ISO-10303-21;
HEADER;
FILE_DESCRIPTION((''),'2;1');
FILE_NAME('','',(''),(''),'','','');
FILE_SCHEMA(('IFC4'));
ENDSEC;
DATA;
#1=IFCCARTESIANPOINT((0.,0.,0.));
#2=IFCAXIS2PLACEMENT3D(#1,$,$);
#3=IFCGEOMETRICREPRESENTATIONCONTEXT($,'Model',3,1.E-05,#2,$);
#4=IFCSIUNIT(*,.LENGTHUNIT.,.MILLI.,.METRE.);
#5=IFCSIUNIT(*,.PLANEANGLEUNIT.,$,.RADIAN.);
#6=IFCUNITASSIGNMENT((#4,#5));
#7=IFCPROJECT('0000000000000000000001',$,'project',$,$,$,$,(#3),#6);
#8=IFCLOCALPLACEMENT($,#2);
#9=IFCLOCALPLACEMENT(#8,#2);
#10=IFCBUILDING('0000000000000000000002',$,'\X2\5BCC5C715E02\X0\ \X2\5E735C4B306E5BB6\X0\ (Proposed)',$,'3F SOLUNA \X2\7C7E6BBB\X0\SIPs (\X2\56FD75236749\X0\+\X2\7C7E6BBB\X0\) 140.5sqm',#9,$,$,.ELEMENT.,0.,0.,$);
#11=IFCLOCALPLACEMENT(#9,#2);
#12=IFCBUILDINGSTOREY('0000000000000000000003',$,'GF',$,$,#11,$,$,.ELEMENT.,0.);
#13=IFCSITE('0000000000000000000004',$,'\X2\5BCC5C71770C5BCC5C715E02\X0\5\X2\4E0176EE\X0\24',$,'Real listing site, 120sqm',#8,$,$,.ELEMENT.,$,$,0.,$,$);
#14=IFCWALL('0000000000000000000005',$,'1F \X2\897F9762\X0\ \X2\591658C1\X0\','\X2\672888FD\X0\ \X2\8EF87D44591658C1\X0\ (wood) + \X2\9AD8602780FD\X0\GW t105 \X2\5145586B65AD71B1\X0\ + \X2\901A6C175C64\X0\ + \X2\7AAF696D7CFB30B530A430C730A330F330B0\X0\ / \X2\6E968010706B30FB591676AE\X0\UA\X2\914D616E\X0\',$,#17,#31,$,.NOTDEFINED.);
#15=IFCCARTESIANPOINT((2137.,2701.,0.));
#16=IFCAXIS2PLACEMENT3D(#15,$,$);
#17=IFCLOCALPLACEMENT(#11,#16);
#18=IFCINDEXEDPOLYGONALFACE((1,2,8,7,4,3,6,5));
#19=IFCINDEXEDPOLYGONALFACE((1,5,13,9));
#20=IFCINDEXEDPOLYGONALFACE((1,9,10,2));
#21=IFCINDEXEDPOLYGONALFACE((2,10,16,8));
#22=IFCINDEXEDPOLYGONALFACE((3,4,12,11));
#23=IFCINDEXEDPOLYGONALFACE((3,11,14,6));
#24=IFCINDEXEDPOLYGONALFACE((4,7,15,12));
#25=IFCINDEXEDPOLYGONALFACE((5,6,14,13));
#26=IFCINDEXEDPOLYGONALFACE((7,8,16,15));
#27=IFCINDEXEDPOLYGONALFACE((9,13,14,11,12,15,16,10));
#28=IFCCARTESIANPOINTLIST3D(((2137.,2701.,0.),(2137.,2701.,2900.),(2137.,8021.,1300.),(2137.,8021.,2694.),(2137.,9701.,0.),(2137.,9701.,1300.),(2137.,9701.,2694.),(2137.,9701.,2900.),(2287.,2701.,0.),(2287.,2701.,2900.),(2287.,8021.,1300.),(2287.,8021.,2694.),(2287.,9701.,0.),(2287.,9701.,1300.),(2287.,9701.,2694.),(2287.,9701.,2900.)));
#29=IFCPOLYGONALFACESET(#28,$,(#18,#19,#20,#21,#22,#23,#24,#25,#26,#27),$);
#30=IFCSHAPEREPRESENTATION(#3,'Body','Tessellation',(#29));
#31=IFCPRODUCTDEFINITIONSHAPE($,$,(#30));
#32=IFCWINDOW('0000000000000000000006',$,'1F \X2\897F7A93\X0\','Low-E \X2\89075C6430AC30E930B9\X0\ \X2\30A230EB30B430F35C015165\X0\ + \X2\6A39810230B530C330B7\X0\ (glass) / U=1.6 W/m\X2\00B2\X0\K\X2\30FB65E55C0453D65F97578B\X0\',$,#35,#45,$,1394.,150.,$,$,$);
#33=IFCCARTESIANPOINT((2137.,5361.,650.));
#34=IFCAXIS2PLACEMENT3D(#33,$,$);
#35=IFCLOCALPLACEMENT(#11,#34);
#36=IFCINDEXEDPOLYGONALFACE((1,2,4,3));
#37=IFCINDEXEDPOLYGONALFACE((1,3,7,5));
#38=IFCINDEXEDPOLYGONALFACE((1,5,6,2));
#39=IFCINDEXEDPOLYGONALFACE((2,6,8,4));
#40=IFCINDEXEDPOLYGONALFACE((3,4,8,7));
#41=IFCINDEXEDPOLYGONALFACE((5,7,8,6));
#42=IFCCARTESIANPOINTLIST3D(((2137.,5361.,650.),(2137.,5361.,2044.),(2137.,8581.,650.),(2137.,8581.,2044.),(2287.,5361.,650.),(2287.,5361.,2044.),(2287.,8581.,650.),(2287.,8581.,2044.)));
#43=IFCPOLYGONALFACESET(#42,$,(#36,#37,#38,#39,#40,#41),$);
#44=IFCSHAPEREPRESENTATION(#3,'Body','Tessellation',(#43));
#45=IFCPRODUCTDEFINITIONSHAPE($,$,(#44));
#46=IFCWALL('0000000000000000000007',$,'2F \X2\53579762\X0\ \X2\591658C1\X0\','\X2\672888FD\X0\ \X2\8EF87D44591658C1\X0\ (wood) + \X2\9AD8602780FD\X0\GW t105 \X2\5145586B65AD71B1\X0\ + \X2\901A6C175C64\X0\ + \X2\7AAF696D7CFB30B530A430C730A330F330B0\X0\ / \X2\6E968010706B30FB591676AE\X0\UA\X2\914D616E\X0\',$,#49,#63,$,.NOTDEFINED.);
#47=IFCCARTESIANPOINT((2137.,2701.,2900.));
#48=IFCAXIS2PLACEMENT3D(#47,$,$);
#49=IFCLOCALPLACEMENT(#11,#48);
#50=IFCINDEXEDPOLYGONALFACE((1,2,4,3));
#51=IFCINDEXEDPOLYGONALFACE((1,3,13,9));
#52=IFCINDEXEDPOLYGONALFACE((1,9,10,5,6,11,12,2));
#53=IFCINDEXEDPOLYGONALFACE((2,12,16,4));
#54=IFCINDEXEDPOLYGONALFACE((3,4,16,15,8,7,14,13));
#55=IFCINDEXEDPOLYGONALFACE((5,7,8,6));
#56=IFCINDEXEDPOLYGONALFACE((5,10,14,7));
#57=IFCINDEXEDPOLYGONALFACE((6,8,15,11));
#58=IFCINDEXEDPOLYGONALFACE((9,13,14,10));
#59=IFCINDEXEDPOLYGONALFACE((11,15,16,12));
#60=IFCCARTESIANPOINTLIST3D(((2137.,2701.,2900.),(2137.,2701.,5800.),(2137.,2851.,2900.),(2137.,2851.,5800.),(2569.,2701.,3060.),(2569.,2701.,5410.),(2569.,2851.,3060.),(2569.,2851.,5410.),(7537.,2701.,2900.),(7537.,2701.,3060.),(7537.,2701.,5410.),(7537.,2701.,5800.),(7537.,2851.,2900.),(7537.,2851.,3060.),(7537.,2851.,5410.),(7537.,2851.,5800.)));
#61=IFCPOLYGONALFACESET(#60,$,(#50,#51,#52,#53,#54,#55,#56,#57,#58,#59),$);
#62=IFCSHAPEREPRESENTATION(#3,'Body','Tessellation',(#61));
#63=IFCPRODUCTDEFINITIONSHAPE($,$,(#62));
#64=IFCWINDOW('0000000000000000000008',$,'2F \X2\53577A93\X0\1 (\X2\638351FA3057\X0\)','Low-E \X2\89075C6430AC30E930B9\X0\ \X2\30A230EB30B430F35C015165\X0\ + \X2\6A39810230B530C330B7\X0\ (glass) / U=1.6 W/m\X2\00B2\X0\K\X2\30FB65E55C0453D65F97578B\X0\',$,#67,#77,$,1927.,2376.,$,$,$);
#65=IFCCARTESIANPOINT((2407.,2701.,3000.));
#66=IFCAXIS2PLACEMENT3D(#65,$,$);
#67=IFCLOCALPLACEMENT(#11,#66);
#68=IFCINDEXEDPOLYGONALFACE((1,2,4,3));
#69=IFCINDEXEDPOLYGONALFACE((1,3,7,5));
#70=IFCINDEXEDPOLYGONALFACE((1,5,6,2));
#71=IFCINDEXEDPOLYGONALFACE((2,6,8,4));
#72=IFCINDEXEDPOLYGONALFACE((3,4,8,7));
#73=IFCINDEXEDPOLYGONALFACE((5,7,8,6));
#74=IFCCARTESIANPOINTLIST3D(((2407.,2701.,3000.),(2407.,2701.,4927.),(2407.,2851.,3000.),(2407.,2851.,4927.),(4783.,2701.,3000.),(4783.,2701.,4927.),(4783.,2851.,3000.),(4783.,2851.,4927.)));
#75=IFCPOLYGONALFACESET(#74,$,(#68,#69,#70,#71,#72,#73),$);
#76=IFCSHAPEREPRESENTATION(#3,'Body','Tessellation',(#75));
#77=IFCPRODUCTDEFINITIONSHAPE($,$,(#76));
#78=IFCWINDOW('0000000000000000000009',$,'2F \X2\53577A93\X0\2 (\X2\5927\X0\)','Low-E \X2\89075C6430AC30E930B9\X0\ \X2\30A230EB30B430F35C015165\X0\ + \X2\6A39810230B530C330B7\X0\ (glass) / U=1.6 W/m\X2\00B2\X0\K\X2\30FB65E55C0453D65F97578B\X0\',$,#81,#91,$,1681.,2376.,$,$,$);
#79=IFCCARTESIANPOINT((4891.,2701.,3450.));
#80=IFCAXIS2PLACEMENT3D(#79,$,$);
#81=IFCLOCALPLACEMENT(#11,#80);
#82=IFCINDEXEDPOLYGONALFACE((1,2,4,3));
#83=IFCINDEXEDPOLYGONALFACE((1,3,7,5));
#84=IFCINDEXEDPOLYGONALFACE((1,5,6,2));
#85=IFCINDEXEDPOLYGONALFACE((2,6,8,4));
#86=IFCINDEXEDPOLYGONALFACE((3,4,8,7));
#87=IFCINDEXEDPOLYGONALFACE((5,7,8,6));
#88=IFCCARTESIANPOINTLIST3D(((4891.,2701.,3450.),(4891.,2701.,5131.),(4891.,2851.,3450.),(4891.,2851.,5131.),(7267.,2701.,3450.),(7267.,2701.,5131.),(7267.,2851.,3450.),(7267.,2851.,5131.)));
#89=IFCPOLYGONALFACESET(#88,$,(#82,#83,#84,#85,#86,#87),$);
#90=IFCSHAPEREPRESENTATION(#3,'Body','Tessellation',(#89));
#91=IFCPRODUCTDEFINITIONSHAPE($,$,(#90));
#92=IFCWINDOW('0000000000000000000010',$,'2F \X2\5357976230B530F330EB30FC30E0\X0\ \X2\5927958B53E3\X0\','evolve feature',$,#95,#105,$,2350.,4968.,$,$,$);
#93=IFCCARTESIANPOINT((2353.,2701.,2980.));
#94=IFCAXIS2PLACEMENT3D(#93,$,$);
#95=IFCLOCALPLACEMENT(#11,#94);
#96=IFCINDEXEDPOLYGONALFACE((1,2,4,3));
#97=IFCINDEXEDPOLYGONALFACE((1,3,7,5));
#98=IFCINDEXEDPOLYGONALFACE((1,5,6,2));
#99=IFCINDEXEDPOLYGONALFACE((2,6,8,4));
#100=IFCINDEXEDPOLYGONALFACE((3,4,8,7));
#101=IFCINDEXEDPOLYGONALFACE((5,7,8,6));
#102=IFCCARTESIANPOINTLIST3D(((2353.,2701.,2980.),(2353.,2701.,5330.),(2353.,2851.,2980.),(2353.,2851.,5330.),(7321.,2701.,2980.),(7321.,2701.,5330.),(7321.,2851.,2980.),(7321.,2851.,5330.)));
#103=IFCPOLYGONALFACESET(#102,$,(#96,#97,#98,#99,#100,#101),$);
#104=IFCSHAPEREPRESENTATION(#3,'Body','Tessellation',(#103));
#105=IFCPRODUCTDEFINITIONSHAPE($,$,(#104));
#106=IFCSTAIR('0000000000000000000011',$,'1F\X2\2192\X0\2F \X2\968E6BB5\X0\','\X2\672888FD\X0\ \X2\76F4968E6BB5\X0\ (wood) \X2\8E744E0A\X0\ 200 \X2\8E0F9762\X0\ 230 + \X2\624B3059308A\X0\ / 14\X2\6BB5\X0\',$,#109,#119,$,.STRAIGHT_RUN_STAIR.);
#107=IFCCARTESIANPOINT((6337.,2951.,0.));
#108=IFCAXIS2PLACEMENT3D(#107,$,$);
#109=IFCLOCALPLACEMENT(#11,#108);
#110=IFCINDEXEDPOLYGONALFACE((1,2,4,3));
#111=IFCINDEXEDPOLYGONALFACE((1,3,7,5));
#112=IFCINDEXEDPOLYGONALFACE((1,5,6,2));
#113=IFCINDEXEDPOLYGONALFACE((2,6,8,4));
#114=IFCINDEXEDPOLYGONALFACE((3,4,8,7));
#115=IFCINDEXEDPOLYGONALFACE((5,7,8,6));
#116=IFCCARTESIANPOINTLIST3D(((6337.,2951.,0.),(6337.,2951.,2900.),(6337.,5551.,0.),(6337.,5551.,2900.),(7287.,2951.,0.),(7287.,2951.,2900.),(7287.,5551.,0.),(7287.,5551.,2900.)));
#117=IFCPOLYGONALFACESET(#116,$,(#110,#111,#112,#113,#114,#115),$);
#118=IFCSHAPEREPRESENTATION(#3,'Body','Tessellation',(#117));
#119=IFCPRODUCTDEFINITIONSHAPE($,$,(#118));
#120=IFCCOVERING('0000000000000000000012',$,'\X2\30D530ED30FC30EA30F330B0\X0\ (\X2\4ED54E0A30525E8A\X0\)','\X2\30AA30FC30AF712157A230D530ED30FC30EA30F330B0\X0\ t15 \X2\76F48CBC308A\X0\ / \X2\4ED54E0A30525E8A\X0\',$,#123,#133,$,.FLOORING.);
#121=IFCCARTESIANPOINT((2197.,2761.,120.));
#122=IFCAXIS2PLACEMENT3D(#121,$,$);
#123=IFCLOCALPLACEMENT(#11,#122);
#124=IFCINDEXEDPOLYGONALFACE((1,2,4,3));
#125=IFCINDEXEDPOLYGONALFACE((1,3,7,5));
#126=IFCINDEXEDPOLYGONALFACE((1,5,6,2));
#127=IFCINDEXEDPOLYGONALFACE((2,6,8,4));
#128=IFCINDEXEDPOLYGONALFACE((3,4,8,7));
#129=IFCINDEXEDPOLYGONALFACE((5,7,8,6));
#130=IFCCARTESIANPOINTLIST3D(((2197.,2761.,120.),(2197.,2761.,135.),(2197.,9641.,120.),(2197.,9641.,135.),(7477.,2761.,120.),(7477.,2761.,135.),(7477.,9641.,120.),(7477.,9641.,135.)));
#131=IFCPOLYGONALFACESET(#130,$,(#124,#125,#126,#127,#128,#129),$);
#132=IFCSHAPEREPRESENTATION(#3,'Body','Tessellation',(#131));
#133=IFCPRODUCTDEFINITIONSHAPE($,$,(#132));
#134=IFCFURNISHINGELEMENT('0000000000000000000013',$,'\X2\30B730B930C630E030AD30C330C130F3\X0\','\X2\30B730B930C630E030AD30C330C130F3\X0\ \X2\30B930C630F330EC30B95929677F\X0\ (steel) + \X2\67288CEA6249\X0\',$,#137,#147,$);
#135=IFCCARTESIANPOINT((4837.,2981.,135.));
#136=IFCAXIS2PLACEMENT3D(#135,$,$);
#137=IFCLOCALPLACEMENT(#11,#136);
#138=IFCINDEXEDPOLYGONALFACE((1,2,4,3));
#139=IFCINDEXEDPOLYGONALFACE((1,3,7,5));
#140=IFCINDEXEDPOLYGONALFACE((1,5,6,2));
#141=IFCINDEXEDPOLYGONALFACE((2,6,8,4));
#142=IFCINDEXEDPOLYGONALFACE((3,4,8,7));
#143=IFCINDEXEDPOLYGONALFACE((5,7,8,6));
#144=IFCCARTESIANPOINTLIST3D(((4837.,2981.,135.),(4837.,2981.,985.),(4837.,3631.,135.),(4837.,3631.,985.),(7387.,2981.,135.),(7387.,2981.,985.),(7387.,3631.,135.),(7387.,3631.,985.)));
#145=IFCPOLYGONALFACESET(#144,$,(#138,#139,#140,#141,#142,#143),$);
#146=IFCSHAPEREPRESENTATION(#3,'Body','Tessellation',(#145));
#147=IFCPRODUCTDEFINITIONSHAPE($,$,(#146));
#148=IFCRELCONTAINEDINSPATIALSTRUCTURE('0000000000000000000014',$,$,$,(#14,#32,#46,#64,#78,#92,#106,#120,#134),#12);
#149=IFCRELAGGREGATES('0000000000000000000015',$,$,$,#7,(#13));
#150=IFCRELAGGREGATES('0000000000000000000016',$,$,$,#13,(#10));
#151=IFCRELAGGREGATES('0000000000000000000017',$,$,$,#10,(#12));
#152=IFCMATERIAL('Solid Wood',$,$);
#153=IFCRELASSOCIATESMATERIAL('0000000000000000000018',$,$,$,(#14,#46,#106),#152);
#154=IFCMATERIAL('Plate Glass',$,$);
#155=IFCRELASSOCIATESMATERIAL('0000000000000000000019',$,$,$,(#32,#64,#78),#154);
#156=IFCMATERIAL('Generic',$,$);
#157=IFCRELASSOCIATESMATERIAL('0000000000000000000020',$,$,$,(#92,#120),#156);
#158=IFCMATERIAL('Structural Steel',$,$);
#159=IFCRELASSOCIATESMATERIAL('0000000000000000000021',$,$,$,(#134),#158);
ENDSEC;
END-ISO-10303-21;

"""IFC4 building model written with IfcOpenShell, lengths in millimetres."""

from ifc_helpers import new_model, si_unit, frame, frame_2d, origin, place, context, project, spatial, rectangle, extrude, material, element, fill, save


model = new_model("IFC4")

# Units and contexts
model_context = context("Model", 3, precision=1e-05, world=origin())
ifc_project = project(units=[si_unit("LENGTHUNIT", "METRE", prefix="MILLI"), si_unit("PLANEANGLEUNIT", "RADIAN")], contexts=[model_context])

# Site, building, storey
site_placement = place(None, origin())
site = spatial("IfcSite", under=ifc_project, at=site_placement, Name="富山県富山市5丁目24", ObjectType="Real listing site, 120sqm", CompositionType="ELEMENT", RefElevation=0.0)
building_placement = place(site_placement, origin())
building = spatial("IfcBuilding", under=site, at=building_placement, Name="富山市 平屋の家 (Proposed)", ObjectType="3F SOLUNA 籾殻SIPs (国産杉+籾殻) 140.5sqm", CompositionType="ELEMENT", ElevationOfRefHeight=0.0, ElevationOfTerrain=0.0)
storey_placement = place(building_placement, origin())
storey = spatial("IfcBuildingStorey", under=building, at=storey_placement, Name="GF", CompositionType="ELEMENT", Elevation=0.0)

# Shared definitions
ifc_material_1 = material(Name="Solid Wood")
ifc_material_2 = material(Name="Generic")

# Shared definitions
ifc_material_3 = material(Name="Plate Glass")

# Wall, opening, window
wall_1_placement = place(storey_placement, frame((2137.0, 2701.0, 0.0)))
wall_1 = element("IfcWall", 1, at=wall_1_placement, inside=storey, material=ifc_material_1, Name="1F 西面 外壁", Description="木製 軸組外壁 (wood) + 高性能GW t105 充填断熱 + 通気層 + 窯業系サイディング / 準耐火・外皮UA配慮", PredefinedType="NOTDEFINED", context=model_context, shape_type="SweptSolid", body=[
    extrude(rectangle(XDim=150.0, YDim=7000.0, at=frame_2d((75.0, 3500.0))), frame((2137.0, 2701.0, 0.0)), (0.0, 0.0, 1.0), 2900.0),
])
opening_1_placement = place(storey_placement, frame((2137.0, 5361.0, 650.0)))
opening_1 = element("IfcOpeningElement", 2, at=opening_1_placement, cuts=wall_1, PredefinedType="NOTDEFINED", context=model_context, shape_type="SweptSolid", body=[
    extrude(rectangle(XDim=150.0, YDim=3220.0, at=frame_2d((75.0, 1610.0))), frame((2137.0, 5361.0, 650.0)), (0.0, 0.0, 1.0), 1394.0),
])
window_1_placement = place(storey_placement, frame((2137.0, 5361.0, 650.0)))
window_1 = element("IfcWindow", 3, at=window_1_placement, inside=storey, material=ifc_material_3, Name="1F 西窓", Description="Low-E 複層ガラス アルゴン封入 + 樹脂サッシ (glass) / U=1.6 W/m²K・日射取得型", OverallHeight=1394.0, OverallWidth=150.0, context=model_context, shape_type="SweptSolid", body=[
    extrude(rectangle(XDim=150.0, YDim=3220.0, at=frame_2d((75.0, 1610.0))), frame((2137.0, 5361.0, 650.0)), (0.0, 0.0, 1.0), 1394.0),
])
fill(opening_1, window_1)

# Wall, openings, windows
wall_2_placement = place(storey_placement, frame((2137.0, 2701.0, 2900.0)))
wall_2 = element("IfcWall", 4, at=wall_2_placement, inside=storey, material=ifc_material_1, Name="2F 南面 外壁", Description="木製 軸組外壁 (wood) + 高性能GW t105 充填断熱 + 通気層 + 窯業系サイディング / 準耐火・外皮UA配慮", PredefinedType="NOTDEFINED", context=model_context, shape_type="SweptSolid", body=[
    extrude(rectangle(XDim=5400.0, YDim=150.0, at=frame_2d((2700.0, 75.0))), frame((2137.0, 2701.0, 2900.0)), (0.0, 0.0, 1.0), 2900.0),
])
opening_2_placement = place(storey_placement, frame((2407.0, 2701.0, 3000.0)))
opening_2 = element("IfcOpeningElement", 5, at=opening_2_placement, cuts=wall_2, PredefinedType="NOTDEFINED", context=model_context, shape_type="SweptSolid", body=[
    extrude(rectangle(XDim=2376.0, YDim=150.0, at=frame_2d((1188.0, 75.0))), frame((2407.0, 2701.0, 3000.0)), (0.0, 0.0, 1.0), 1927.0),
])
opening_3_placement = place(storey_placement, frame((4891.0, 2701.0, 3450.0)))
opening_3 = element("IfcOpeningElement", 6, at=opening_3_placement, cuts=wall_2, PredefinedType="NOTDEFINED", context=model_context, shape_type="SweptSolid", body=[
    extrude(rectangle(XDim=2376.0, YDim=150.0, at=frame_2d((1188.0, 75.0))), frame((4891.0, 2701.0, 3450.0)), (0.0, 0.0, 1.0), 1681.0),
])
opening_4_placement = place(storey_placement, frame((2353.0, 2701.0, 2980.0)))
opening_4 = element("IfcOpeningElement", 7, at=opening_4_placement, cuts=wall_2, PredefinedType="NOTDEFINED", context=model_context, shape_type="SweptSolid", body=[
    extrude(rectangle(XDim=4968.0, YDim=150.0, at=frame_2d((2484.0, 75.0))), frame((2353.0, 2701.0, 2980.0)), (0.0, 0.0, 1.0), 2350.0),
])
window_2_placement = place(storey_placement, frame((2407.0, 2701.0, 3000.0)))
window_2 = element("IfcWindow", 8, at=window_2_placement, inside=storey, material=ifc_material_3, Name="2F 南窓1 (掃出し)", Description="Low-E 複層ガラス アルゴン封入 + 樹脂サッシ (glass) / U=1.6 W/m²K・日射取得型", OverallHeight=1927.0, OverallWidth=2376.0, context=model_context, shape_type="SweptSolid", body=[
    extrude(rectangle(XDim=2376.0, YDim=150.0, at=frame_2d((1188.0, 75.0))), frame((2407.0, 2701.0, 3000.0)), (0.0, 0.0, 1.0), 1927.0),
])
fill(opening_2, window_2)
window_3_placement = place(storey_placement, frame((4891.0, 2701.0, 3450.0)))
window_3 = element("IfcWindow", 9, at=window_3_placement, inside=storey, material=ifc_material_3, Name="2F 南窓2 (大)", Description="Low-E 複層ガラス アルゴン封入 + 樹脂サッシ (glass) / U=1.6 W/m²K・日射取得型", OverallHeight=1681.0, OverallWidth=2376.0, context=model_context, shape_type="SweptSolid", body=[
    extrude(rectangle(XDim=2376.0, YDim=150.0, at=frame_2d((1188.0, 75.0))), frame((4891.0, 2701.0, 3450.0)), (0.0, 0.0, 1.0), 1681.0),
])
fill(opening_3, window_3)
window_4_placement = place(storey_placement, frame((2353.0, 2701.0, 2980.0)))
window_4 = element("IfcWindow", 10, at=window_4_placement, inside=storey, material=ifc_material_2, Name="2F 南面サンルーム 大開口", Description="evolve feature", OverallHeight=2350.0, OverallWidth=4968.0, context=model_context, shape_type="SweptSolid", body=[
    extrude(rectangle(XDim=4968.0, YDim=150.0, at=frame_2d((2484.0, 75.0))), frame((2353.0, 2701.0, 2980.0)), (0.0, 0.0, 1.0), 2350.0),
])
fill(opening_4, window_4)

# Stair
stair_placement = place(storey_placement, frame((6337.0, 2951.0, 0.0)))
element("IfcStair", 11, at=stair_placement, inside=storey, material=ifc_material_1, Name="1F→2F 階段", Description="木製 直階段 (wood) 蹴上 200 踏面 230 + 手すり / 14段", PredefinedType="STRAIGHT_RUN_STAIR", context=model_context, shape_type="SweptSolid", body=[
    extrude(rectangle(XDim=950.0, YDim=2600.0, at=frame_2d((475.0, 1300.0))), frame((6337.0, 2951.0, 0.0)), (0.0, 0.0, 1.0), 2900.0),
])

# Covering
covering_placement = place(storey_placement, frame((2197.0, 2761.0, 120.0)))
element("IfcCovering", 12, at=covering_placement, inside=storey, material=ifc_material_2, Name="フローリング (仕上げ床)", Description="オーク無垢フローリング t15 直貼り / 仕上げ床", PredefinedType="FLOORING", context=model_context, shape_type="SweptSolid", body=[
    extrude(rectangle(XDim=5280.0, YDim=6880.0, at=frame_2d((2640.0, 3440.0))), frame((2197.0, 2761.0, 120.0)), (0.0, 0.0, 1.0), 15.0),
])

# Furnishing element
ifc_material_4 = material(Name="Structural Steel")
furnishing_placement = place(storey_placement, frame((4837.0, 2981.0, 135.0)))
element("IfcFurnishingElement", 13, at=furnishing_placement, inside=storey, material=ifc_material_4, Name="システムキッチン", Description="システムキッチン ステンレス天板 (steel) + 木質扉", context=model_context, shape_type="SweptSolid", body=[
    extrude(rectangle(XDim=2550.0, YDim=650.0, at=frame_2d((1275.0, 325.0))), frame((4837.0, 2981.0, 135.0)), (0.0, 0.0, 1.0), 850.0),
])

save(model, "model.ifc")
